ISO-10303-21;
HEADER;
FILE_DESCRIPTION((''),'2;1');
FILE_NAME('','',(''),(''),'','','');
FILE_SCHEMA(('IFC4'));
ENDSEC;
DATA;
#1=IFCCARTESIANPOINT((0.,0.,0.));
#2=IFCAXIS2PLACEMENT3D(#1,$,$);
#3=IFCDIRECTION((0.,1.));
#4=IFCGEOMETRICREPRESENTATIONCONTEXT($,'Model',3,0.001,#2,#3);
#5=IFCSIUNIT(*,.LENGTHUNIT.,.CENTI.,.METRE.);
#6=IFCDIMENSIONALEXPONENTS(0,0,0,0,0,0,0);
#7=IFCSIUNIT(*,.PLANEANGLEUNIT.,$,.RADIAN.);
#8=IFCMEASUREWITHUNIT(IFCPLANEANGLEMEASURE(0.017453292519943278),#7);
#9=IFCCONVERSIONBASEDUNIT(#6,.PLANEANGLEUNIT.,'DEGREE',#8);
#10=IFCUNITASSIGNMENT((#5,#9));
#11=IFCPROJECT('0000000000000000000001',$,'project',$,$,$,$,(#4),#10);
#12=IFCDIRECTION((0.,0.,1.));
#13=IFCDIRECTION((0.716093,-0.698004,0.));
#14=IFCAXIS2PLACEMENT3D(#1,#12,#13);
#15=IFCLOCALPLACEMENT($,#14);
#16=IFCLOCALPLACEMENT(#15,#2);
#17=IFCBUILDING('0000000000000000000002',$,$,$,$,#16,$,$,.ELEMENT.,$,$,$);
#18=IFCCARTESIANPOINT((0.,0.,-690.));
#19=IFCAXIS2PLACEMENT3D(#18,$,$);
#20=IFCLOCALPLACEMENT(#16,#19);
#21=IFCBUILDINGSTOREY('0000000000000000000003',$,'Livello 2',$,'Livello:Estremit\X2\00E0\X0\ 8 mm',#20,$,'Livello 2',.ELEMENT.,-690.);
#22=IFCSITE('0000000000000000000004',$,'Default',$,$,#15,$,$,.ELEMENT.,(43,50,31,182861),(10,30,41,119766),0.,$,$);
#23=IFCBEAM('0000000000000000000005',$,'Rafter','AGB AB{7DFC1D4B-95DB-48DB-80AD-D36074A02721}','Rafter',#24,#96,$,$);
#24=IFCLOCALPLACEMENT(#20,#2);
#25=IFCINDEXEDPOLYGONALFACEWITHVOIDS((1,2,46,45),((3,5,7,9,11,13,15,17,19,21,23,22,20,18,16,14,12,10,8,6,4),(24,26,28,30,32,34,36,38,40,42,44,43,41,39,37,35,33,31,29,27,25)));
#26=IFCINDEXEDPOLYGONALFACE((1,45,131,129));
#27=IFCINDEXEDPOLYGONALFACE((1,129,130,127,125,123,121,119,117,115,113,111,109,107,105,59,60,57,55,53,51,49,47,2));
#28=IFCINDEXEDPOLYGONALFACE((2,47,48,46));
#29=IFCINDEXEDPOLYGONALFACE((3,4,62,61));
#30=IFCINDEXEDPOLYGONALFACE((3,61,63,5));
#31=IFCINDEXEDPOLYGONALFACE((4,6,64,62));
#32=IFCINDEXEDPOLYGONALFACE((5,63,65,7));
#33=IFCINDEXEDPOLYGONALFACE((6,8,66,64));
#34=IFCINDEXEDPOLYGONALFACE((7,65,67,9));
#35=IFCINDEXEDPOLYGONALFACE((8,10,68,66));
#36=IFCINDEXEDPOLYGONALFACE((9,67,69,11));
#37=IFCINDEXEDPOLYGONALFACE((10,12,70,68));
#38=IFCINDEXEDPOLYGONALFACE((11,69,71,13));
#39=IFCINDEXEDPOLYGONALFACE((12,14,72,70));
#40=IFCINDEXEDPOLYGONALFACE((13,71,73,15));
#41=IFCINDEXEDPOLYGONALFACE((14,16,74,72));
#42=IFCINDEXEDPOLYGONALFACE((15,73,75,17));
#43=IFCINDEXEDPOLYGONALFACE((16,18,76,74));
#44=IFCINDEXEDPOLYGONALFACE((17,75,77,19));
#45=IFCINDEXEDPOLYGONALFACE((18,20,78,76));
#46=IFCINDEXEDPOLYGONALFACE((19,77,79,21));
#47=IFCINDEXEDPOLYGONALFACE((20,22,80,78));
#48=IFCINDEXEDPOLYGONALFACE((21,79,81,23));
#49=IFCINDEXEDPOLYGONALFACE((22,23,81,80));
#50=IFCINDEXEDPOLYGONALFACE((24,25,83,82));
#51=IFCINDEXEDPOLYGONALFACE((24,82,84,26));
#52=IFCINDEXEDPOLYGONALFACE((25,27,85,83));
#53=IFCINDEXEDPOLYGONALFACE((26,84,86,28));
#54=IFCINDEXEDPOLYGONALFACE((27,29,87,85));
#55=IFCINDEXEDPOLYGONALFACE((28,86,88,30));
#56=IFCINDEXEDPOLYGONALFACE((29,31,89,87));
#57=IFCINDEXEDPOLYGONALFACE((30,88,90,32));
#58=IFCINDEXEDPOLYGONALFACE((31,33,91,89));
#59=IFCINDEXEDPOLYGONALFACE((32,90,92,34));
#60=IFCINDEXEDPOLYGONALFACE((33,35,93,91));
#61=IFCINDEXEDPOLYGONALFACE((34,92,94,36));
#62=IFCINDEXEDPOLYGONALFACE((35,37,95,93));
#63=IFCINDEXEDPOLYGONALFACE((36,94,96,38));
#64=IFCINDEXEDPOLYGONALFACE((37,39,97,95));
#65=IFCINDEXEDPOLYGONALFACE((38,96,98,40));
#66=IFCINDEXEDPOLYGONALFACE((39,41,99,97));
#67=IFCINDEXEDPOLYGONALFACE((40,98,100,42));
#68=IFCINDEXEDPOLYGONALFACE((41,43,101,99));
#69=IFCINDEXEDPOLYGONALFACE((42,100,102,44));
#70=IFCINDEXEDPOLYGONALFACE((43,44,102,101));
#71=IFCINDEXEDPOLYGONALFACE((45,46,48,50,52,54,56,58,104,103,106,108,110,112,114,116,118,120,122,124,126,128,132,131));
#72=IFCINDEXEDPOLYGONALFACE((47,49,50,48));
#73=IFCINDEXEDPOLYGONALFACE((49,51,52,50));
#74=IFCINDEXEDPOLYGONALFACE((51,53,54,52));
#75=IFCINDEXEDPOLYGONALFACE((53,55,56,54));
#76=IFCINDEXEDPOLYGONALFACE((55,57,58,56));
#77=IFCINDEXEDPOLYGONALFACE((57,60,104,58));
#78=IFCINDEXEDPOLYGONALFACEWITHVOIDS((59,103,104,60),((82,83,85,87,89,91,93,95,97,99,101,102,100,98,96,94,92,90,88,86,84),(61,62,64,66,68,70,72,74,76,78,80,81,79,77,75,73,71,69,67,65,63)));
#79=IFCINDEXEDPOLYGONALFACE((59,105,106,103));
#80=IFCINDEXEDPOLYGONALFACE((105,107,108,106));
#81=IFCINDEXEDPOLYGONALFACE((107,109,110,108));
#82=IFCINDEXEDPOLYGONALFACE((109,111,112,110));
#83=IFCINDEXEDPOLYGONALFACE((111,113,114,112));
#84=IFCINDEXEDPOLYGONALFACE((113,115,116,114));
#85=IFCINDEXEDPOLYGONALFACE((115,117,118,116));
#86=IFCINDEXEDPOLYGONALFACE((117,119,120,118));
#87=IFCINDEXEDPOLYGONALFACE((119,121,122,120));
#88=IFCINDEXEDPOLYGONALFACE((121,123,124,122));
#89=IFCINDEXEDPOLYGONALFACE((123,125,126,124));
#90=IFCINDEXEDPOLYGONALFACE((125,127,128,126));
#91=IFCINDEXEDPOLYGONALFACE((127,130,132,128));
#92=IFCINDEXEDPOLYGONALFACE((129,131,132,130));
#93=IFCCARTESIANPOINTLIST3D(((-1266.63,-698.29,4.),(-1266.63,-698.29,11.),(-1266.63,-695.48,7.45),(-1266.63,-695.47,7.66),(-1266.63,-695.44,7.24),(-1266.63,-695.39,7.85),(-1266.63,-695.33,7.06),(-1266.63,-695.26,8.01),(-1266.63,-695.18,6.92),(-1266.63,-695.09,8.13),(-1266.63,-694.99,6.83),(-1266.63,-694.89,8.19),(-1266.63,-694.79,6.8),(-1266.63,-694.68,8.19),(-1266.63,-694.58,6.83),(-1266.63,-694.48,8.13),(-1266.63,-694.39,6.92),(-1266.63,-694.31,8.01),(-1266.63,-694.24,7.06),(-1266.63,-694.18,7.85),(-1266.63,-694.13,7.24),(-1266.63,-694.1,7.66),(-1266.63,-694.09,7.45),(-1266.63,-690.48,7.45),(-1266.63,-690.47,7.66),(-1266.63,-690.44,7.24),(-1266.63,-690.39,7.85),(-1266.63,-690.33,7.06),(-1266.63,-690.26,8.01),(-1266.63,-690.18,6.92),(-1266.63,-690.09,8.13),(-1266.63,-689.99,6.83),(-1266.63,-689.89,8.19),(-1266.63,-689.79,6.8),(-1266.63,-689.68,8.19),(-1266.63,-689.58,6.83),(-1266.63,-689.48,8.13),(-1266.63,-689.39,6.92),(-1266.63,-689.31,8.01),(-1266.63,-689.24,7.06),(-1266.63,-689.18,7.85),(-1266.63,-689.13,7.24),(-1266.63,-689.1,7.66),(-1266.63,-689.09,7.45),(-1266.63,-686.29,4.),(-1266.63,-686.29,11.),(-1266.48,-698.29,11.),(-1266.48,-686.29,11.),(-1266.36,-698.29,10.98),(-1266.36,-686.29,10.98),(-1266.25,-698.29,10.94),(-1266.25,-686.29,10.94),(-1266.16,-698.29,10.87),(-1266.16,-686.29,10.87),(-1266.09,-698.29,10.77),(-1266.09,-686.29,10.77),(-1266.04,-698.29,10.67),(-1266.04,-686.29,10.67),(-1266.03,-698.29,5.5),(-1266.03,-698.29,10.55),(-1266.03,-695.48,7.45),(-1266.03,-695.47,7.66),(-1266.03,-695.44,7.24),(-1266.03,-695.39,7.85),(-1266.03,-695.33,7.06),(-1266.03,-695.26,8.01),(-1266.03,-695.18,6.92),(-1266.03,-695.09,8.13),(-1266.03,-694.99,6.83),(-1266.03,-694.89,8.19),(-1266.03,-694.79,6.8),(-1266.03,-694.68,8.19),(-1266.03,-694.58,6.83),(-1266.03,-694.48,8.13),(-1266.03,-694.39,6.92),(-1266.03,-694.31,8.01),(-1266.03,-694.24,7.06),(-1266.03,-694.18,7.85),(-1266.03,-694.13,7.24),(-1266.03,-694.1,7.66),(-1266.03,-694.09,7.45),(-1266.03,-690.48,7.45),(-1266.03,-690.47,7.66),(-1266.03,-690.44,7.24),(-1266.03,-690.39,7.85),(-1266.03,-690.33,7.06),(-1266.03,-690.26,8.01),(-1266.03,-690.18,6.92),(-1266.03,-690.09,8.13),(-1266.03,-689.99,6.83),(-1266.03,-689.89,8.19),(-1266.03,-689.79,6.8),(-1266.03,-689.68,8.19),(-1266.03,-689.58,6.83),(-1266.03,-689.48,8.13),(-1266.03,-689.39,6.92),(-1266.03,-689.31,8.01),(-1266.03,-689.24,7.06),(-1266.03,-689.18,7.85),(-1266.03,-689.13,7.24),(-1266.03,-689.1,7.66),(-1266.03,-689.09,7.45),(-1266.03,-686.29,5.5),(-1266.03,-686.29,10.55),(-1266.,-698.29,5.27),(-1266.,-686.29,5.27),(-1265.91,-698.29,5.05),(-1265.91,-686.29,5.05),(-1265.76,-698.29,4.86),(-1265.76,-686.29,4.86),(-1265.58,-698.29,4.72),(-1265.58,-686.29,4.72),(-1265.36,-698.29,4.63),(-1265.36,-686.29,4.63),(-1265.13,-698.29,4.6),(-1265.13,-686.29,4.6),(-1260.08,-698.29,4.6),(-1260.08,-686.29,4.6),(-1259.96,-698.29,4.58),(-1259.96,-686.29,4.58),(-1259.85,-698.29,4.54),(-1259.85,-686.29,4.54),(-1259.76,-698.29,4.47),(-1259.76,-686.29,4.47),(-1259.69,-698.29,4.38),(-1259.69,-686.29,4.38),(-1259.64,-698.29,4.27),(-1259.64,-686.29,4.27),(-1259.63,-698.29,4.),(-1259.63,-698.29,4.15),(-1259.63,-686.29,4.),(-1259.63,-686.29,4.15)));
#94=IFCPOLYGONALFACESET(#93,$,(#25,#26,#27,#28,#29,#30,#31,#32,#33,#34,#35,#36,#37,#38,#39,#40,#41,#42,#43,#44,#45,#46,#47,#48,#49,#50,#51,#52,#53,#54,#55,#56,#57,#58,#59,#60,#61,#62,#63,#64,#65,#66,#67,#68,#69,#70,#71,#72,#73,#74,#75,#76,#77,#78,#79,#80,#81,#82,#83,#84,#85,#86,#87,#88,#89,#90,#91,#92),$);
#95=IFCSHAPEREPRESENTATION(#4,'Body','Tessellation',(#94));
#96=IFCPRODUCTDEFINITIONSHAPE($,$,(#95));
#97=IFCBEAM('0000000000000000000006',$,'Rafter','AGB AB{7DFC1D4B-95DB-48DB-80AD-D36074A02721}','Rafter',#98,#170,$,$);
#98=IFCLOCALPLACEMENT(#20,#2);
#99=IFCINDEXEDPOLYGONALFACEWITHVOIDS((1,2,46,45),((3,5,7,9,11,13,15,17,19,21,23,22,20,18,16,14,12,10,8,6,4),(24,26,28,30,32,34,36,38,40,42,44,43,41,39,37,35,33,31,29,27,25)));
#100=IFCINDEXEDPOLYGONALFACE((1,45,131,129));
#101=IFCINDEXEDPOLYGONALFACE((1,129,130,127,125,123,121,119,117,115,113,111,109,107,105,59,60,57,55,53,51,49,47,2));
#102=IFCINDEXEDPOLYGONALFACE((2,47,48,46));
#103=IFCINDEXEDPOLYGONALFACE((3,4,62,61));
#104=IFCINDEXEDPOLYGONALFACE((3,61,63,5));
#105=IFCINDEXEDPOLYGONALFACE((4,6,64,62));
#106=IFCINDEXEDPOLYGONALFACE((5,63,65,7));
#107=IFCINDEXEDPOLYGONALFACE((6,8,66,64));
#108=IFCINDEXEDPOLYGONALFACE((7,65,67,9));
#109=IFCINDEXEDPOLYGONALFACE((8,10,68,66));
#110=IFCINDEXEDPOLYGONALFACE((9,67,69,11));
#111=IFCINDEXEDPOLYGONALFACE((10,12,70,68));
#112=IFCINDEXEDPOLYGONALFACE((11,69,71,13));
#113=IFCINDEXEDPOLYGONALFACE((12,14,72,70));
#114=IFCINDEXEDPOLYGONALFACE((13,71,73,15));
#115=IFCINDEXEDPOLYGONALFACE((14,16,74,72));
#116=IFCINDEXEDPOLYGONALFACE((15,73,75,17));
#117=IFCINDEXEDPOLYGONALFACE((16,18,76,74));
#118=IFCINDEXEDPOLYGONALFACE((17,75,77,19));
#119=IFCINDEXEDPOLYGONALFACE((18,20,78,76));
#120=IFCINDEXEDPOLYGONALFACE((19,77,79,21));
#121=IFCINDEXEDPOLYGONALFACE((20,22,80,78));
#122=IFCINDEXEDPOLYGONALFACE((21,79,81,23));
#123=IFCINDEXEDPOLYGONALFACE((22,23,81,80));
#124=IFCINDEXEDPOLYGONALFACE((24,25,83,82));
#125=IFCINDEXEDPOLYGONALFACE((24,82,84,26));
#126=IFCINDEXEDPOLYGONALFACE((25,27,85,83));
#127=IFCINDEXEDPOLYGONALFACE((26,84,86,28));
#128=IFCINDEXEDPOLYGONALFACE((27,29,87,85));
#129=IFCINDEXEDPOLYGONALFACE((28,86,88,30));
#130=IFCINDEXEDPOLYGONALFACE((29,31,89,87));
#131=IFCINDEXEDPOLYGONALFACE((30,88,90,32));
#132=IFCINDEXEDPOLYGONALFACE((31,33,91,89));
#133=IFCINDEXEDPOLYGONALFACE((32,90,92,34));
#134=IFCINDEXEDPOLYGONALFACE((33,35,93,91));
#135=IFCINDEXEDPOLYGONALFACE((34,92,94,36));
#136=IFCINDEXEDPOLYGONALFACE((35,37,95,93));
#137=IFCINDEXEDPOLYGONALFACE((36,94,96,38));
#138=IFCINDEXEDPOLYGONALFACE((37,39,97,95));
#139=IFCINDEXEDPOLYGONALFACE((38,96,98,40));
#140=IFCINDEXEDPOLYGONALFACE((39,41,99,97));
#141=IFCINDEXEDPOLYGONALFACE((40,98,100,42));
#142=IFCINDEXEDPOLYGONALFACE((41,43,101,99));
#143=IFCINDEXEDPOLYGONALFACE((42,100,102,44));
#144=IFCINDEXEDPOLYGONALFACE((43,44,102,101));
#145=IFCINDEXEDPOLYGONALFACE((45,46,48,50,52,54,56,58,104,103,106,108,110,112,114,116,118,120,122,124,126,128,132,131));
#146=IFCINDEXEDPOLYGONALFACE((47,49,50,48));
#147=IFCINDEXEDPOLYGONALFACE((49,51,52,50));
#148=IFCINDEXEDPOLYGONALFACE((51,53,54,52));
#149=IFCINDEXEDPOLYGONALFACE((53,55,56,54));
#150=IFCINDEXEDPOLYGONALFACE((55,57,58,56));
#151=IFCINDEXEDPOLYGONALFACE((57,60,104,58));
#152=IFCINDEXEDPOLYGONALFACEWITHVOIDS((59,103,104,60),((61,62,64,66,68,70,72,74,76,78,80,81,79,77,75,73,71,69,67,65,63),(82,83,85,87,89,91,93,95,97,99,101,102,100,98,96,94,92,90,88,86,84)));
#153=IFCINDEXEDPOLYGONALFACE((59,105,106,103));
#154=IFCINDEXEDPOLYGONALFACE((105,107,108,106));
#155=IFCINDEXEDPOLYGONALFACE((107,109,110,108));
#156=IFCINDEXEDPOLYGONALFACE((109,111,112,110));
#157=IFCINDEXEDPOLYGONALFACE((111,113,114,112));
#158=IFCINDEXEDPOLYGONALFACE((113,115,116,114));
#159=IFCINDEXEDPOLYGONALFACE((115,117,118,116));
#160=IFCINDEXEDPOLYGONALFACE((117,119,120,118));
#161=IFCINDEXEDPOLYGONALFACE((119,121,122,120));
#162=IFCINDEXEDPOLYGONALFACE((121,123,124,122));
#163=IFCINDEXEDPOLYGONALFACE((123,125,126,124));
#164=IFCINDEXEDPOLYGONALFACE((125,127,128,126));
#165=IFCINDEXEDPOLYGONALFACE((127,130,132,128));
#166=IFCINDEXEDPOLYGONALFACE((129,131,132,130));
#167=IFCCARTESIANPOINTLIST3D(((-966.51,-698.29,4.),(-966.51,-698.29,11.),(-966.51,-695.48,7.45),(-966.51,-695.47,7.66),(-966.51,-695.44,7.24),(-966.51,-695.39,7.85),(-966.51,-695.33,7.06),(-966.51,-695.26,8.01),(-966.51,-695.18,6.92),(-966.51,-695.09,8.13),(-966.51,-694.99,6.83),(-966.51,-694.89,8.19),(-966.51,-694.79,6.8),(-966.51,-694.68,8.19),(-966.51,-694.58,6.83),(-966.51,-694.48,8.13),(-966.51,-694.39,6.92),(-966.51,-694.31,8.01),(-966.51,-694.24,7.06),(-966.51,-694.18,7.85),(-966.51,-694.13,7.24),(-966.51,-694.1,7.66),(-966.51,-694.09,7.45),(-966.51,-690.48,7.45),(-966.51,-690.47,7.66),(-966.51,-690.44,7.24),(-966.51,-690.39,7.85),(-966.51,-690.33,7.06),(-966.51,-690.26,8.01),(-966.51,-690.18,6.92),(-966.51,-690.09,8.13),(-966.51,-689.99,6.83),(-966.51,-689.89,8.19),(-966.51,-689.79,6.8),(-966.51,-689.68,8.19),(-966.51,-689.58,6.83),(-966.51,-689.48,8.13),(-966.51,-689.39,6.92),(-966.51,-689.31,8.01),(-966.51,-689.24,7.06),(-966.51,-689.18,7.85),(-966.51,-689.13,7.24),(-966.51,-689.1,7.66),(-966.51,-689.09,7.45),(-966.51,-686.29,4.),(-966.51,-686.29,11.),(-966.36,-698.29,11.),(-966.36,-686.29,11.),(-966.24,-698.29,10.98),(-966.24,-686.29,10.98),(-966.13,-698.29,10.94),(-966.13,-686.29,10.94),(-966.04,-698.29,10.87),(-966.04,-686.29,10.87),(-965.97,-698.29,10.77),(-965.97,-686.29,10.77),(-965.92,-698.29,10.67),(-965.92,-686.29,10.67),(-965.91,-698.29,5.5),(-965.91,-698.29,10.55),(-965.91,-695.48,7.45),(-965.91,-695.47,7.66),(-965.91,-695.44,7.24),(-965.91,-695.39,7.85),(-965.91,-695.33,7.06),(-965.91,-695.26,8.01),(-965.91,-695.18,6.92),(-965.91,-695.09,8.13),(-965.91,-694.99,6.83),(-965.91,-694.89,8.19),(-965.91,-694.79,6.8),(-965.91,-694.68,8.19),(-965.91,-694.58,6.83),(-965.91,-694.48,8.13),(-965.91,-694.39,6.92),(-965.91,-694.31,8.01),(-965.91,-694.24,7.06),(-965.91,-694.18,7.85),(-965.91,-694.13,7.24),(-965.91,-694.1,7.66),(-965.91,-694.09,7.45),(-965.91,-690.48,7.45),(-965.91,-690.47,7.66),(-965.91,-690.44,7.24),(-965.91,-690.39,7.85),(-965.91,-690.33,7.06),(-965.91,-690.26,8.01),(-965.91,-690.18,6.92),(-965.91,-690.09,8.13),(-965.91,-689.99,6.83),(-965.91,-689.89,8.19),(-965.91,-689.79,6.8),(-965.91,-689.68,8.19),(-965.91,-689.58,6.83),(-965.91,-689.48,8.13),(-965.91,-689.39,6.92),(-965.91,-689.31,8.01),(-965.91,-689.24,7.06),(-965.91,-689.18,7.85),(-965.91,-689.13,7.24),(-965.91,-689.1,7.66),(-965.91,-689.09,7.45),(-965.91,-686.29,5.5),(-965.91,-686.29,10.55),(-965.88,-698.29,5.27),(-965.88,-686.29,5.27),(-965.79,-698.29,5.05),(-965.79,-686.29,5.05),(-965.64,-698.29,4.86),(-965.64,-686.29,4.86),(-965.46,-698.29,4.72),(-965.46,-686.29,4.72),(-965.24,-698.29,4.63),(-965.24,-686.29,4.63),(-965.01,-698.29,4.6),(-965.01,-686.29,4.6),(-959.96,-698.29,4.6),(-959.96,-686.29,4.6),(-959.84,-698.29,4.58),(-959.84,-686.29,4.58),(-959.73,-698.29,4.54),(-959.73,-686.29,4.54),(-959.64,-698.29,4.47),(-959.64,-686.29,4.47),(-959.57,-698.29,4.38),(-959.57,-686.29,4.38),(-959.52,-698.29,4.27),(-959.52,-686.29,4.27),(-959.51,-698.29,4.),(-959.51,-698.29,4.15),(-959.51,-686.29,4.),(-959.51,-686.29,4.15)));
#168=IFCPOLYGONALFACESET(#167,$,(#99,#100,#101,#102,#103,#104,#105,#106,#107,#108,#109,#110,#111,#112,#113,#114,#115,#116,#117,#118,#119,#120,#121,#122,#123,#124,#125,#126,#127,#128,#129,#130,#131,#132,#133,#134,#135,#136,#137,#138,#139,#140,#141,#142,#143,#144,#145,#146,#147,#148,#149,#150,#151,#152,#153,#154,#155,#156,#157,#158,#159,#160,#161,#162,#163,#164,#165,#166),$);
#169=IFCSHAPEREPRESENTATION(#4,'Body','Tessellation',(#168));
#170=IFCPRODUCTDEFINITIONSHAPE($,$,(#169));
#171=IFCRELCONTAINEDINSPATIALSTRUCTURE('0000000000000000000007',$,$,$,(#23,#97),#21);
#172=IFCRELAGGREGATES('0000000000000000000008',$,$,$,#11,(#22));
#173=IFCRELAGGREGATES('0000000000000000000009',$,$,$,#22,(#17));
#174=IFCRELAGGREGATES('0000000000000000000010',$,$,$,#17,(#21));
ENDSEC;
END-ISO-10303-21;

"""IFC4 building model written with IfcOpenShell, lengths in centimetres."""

from ifc_helpers import new_model, entity, si_unit, converted_unit, direction, frame, frame_2d, origin, place, context, project, spatial, circle, l_section, extrude, element, save


model = new_model("IFC4")

# Units and contexts
model_context = context("Model", 3, precision=0.001, world=origin(), true_north=direction((0.0, 1.0)))
ifc_project = project(units=[si_unit("LENGTHUNIT", "METRE", prefix="CENTI"), converted_unit("PLANEANGLEUNIT", "DEGREE", entity("IfcPlaneAngleMeasure", 0.017453292519943278), si_unit("PLANEANGLEUNIT", "RADIAN"), dimensions=[0, 0, 0, 0, 0, 0, 0])], contexts=[model_context])

# Site, building, storey
site_placement = place(None, frame((0.0, 0.0, 0.0), z_axis=(0.0, 0.0, 1.0), x_axis=(0.716093, -0.698004, 0.0)))
site = spatial("IfcSite", under=ifc_project, at=site_placement, Name="Default", CompositionType="ELEMENT", RefLatitude=(43, 50, 31, 182861), RefLongitude=(10, 30, 41, 119766), RefElevation=0.0)
building_placement = place(site_placement, origin())
building = spatial("IfcBuilding", under=site, at=building_placement, CompositionType="ELEMENT")
storey_placement = place(building_placement, frame((0.0, 0.0, -690.0)))
storey = spatial("IfcBuildingStorey", under=building, at=storey_placement, Name="Livello 2", ObjectType="Livello:Estremità 8 mm", LongName="Livello 2", CompositionType="ELEMENT", Elevation=-690.0)

# Beams, openings
beam_1_placement = place(storey_placement, frame((-1264.7, -698.29, 5.93), z_axis=(0.0, -1.0, 0.0), x_axis=(1.0, 0.0, 0.0)))
beam_1 = element("IfcBeam", 1, at=beam_1_placement, inside=storey, Name="Rafter", Description="AGB AB{7DFC1D4B-95DB-48DB-80AD-D36074A02721}", ObjectType="Rafter", context=model_context, shape_type="SweptSolid", body=[
    extrude(l_section(Depth=7.0, Width=7.0, Thickness=0.6, FilletRadius=0.9, EdgeRadius=0.45, at=frame_2d((1.57, 1.57))), origin(), (0.0, 0.0, -1.0), 12.0),
])
opening_1_placement = place(beam_1_placement, frame((-1.98, 1.57, -4.2), z_axis=(-1.0, 0.0, 0.0), x_axis=(0.0, -1.0, 0.0)))
element("IfcOpeningElement", 2, at=opening_1_placement, cuts=beam_1, ObjectType="Opening", context=model_context, shape_type="SweptSolid", body=[
    extrude(circle(Radius=0.7, at=frame_2d((0.0, 0.7), x_axis=(1.0, 0.0))), origin(), (0.0, 0.0, -1.0), 0.7),
])
opening_2_placement = place(beam_1_placement, frame((-1.98, 1.57, -9.2), z_axis=(-1.0, 0.0, 0.0), x_axis=(0.0, -1.0, 0.0)))
element("IfcOpeningElement", 3, at=opening_2_placement, cuts=beam_1, ObjectType="Opening", context=model_context, shape_type="SweptSolid", body=[
    extrude(circle(Radius=0.7, at=frame_2d((0.0, 0.7), x_axis=(1.0, 0.0))), origin(), (0.0, 0.0, -1.0), 0.7),
])
beam_2_placement = place(storey_placement, frame((-964.58, -698.29, 5.93), z_axis=(0.0, -1.0, 0.0), x_axis=(1.0, 0.0, 0.0)))
beam_2 = element("IfcBeam", 4, at=beam_2_placement, inside=storey, Name="Rafter", Description="AGB AB{7DFC1D4B-95DB-48DB-80AD-D36074A02721}", ObjectType="Rafter", context=model_context, shape_type="SweptSolid", body=[
    extrude(l_section(Depth=7.0, Width=7.0, Thickness=0.6, FilletRadius=0.9, EdgeRadius=0.45, at=frame_2d((1.57, 1.57))), origin(), (0.0, 0.0, -1.0), 12.0),
])
opening_3_placement = place(beam_2_placement, frame((-1.98, 1.57, -4.2), z_axis=(-1.0, 0.0, 0.0), x_axis=(0.0, -1.0, 0.0)))
element("IfcOpeningElement", 5, at=opening_3_placement, cuts=beam_2, ObjectType="Opening", context=model_context, shape_type="SweptSolid", body=[
    extrude(circle(Radius=0.7, at=frame_2d((0.0, 0.7), x_axis=(1.0, 0.0))), origin(), (0.0, 0.0, -1.0), 0.7),
])
opening_4_placement = place(beam_2_placement, frame((-1.98, 1.57, -9.2), z_axis=(-1.0, 0.0, 0.0), x_axis=(0.0, -1.0, 0.0)))
element("IfcOpeningElement", 6, at=opening_4_placement, cuts=beam_2, ObjectType="Opening", context=model_context, shape_type="SweptSolid", body=[
    extrude(circle(Radius=0.7, at=frame_2d((0.0, 0.7), x_axis=(1.0, 0.0))), origin(), (0.0, 0.0, -1.0), 0.7),
])

save(model, "model.ifc")
